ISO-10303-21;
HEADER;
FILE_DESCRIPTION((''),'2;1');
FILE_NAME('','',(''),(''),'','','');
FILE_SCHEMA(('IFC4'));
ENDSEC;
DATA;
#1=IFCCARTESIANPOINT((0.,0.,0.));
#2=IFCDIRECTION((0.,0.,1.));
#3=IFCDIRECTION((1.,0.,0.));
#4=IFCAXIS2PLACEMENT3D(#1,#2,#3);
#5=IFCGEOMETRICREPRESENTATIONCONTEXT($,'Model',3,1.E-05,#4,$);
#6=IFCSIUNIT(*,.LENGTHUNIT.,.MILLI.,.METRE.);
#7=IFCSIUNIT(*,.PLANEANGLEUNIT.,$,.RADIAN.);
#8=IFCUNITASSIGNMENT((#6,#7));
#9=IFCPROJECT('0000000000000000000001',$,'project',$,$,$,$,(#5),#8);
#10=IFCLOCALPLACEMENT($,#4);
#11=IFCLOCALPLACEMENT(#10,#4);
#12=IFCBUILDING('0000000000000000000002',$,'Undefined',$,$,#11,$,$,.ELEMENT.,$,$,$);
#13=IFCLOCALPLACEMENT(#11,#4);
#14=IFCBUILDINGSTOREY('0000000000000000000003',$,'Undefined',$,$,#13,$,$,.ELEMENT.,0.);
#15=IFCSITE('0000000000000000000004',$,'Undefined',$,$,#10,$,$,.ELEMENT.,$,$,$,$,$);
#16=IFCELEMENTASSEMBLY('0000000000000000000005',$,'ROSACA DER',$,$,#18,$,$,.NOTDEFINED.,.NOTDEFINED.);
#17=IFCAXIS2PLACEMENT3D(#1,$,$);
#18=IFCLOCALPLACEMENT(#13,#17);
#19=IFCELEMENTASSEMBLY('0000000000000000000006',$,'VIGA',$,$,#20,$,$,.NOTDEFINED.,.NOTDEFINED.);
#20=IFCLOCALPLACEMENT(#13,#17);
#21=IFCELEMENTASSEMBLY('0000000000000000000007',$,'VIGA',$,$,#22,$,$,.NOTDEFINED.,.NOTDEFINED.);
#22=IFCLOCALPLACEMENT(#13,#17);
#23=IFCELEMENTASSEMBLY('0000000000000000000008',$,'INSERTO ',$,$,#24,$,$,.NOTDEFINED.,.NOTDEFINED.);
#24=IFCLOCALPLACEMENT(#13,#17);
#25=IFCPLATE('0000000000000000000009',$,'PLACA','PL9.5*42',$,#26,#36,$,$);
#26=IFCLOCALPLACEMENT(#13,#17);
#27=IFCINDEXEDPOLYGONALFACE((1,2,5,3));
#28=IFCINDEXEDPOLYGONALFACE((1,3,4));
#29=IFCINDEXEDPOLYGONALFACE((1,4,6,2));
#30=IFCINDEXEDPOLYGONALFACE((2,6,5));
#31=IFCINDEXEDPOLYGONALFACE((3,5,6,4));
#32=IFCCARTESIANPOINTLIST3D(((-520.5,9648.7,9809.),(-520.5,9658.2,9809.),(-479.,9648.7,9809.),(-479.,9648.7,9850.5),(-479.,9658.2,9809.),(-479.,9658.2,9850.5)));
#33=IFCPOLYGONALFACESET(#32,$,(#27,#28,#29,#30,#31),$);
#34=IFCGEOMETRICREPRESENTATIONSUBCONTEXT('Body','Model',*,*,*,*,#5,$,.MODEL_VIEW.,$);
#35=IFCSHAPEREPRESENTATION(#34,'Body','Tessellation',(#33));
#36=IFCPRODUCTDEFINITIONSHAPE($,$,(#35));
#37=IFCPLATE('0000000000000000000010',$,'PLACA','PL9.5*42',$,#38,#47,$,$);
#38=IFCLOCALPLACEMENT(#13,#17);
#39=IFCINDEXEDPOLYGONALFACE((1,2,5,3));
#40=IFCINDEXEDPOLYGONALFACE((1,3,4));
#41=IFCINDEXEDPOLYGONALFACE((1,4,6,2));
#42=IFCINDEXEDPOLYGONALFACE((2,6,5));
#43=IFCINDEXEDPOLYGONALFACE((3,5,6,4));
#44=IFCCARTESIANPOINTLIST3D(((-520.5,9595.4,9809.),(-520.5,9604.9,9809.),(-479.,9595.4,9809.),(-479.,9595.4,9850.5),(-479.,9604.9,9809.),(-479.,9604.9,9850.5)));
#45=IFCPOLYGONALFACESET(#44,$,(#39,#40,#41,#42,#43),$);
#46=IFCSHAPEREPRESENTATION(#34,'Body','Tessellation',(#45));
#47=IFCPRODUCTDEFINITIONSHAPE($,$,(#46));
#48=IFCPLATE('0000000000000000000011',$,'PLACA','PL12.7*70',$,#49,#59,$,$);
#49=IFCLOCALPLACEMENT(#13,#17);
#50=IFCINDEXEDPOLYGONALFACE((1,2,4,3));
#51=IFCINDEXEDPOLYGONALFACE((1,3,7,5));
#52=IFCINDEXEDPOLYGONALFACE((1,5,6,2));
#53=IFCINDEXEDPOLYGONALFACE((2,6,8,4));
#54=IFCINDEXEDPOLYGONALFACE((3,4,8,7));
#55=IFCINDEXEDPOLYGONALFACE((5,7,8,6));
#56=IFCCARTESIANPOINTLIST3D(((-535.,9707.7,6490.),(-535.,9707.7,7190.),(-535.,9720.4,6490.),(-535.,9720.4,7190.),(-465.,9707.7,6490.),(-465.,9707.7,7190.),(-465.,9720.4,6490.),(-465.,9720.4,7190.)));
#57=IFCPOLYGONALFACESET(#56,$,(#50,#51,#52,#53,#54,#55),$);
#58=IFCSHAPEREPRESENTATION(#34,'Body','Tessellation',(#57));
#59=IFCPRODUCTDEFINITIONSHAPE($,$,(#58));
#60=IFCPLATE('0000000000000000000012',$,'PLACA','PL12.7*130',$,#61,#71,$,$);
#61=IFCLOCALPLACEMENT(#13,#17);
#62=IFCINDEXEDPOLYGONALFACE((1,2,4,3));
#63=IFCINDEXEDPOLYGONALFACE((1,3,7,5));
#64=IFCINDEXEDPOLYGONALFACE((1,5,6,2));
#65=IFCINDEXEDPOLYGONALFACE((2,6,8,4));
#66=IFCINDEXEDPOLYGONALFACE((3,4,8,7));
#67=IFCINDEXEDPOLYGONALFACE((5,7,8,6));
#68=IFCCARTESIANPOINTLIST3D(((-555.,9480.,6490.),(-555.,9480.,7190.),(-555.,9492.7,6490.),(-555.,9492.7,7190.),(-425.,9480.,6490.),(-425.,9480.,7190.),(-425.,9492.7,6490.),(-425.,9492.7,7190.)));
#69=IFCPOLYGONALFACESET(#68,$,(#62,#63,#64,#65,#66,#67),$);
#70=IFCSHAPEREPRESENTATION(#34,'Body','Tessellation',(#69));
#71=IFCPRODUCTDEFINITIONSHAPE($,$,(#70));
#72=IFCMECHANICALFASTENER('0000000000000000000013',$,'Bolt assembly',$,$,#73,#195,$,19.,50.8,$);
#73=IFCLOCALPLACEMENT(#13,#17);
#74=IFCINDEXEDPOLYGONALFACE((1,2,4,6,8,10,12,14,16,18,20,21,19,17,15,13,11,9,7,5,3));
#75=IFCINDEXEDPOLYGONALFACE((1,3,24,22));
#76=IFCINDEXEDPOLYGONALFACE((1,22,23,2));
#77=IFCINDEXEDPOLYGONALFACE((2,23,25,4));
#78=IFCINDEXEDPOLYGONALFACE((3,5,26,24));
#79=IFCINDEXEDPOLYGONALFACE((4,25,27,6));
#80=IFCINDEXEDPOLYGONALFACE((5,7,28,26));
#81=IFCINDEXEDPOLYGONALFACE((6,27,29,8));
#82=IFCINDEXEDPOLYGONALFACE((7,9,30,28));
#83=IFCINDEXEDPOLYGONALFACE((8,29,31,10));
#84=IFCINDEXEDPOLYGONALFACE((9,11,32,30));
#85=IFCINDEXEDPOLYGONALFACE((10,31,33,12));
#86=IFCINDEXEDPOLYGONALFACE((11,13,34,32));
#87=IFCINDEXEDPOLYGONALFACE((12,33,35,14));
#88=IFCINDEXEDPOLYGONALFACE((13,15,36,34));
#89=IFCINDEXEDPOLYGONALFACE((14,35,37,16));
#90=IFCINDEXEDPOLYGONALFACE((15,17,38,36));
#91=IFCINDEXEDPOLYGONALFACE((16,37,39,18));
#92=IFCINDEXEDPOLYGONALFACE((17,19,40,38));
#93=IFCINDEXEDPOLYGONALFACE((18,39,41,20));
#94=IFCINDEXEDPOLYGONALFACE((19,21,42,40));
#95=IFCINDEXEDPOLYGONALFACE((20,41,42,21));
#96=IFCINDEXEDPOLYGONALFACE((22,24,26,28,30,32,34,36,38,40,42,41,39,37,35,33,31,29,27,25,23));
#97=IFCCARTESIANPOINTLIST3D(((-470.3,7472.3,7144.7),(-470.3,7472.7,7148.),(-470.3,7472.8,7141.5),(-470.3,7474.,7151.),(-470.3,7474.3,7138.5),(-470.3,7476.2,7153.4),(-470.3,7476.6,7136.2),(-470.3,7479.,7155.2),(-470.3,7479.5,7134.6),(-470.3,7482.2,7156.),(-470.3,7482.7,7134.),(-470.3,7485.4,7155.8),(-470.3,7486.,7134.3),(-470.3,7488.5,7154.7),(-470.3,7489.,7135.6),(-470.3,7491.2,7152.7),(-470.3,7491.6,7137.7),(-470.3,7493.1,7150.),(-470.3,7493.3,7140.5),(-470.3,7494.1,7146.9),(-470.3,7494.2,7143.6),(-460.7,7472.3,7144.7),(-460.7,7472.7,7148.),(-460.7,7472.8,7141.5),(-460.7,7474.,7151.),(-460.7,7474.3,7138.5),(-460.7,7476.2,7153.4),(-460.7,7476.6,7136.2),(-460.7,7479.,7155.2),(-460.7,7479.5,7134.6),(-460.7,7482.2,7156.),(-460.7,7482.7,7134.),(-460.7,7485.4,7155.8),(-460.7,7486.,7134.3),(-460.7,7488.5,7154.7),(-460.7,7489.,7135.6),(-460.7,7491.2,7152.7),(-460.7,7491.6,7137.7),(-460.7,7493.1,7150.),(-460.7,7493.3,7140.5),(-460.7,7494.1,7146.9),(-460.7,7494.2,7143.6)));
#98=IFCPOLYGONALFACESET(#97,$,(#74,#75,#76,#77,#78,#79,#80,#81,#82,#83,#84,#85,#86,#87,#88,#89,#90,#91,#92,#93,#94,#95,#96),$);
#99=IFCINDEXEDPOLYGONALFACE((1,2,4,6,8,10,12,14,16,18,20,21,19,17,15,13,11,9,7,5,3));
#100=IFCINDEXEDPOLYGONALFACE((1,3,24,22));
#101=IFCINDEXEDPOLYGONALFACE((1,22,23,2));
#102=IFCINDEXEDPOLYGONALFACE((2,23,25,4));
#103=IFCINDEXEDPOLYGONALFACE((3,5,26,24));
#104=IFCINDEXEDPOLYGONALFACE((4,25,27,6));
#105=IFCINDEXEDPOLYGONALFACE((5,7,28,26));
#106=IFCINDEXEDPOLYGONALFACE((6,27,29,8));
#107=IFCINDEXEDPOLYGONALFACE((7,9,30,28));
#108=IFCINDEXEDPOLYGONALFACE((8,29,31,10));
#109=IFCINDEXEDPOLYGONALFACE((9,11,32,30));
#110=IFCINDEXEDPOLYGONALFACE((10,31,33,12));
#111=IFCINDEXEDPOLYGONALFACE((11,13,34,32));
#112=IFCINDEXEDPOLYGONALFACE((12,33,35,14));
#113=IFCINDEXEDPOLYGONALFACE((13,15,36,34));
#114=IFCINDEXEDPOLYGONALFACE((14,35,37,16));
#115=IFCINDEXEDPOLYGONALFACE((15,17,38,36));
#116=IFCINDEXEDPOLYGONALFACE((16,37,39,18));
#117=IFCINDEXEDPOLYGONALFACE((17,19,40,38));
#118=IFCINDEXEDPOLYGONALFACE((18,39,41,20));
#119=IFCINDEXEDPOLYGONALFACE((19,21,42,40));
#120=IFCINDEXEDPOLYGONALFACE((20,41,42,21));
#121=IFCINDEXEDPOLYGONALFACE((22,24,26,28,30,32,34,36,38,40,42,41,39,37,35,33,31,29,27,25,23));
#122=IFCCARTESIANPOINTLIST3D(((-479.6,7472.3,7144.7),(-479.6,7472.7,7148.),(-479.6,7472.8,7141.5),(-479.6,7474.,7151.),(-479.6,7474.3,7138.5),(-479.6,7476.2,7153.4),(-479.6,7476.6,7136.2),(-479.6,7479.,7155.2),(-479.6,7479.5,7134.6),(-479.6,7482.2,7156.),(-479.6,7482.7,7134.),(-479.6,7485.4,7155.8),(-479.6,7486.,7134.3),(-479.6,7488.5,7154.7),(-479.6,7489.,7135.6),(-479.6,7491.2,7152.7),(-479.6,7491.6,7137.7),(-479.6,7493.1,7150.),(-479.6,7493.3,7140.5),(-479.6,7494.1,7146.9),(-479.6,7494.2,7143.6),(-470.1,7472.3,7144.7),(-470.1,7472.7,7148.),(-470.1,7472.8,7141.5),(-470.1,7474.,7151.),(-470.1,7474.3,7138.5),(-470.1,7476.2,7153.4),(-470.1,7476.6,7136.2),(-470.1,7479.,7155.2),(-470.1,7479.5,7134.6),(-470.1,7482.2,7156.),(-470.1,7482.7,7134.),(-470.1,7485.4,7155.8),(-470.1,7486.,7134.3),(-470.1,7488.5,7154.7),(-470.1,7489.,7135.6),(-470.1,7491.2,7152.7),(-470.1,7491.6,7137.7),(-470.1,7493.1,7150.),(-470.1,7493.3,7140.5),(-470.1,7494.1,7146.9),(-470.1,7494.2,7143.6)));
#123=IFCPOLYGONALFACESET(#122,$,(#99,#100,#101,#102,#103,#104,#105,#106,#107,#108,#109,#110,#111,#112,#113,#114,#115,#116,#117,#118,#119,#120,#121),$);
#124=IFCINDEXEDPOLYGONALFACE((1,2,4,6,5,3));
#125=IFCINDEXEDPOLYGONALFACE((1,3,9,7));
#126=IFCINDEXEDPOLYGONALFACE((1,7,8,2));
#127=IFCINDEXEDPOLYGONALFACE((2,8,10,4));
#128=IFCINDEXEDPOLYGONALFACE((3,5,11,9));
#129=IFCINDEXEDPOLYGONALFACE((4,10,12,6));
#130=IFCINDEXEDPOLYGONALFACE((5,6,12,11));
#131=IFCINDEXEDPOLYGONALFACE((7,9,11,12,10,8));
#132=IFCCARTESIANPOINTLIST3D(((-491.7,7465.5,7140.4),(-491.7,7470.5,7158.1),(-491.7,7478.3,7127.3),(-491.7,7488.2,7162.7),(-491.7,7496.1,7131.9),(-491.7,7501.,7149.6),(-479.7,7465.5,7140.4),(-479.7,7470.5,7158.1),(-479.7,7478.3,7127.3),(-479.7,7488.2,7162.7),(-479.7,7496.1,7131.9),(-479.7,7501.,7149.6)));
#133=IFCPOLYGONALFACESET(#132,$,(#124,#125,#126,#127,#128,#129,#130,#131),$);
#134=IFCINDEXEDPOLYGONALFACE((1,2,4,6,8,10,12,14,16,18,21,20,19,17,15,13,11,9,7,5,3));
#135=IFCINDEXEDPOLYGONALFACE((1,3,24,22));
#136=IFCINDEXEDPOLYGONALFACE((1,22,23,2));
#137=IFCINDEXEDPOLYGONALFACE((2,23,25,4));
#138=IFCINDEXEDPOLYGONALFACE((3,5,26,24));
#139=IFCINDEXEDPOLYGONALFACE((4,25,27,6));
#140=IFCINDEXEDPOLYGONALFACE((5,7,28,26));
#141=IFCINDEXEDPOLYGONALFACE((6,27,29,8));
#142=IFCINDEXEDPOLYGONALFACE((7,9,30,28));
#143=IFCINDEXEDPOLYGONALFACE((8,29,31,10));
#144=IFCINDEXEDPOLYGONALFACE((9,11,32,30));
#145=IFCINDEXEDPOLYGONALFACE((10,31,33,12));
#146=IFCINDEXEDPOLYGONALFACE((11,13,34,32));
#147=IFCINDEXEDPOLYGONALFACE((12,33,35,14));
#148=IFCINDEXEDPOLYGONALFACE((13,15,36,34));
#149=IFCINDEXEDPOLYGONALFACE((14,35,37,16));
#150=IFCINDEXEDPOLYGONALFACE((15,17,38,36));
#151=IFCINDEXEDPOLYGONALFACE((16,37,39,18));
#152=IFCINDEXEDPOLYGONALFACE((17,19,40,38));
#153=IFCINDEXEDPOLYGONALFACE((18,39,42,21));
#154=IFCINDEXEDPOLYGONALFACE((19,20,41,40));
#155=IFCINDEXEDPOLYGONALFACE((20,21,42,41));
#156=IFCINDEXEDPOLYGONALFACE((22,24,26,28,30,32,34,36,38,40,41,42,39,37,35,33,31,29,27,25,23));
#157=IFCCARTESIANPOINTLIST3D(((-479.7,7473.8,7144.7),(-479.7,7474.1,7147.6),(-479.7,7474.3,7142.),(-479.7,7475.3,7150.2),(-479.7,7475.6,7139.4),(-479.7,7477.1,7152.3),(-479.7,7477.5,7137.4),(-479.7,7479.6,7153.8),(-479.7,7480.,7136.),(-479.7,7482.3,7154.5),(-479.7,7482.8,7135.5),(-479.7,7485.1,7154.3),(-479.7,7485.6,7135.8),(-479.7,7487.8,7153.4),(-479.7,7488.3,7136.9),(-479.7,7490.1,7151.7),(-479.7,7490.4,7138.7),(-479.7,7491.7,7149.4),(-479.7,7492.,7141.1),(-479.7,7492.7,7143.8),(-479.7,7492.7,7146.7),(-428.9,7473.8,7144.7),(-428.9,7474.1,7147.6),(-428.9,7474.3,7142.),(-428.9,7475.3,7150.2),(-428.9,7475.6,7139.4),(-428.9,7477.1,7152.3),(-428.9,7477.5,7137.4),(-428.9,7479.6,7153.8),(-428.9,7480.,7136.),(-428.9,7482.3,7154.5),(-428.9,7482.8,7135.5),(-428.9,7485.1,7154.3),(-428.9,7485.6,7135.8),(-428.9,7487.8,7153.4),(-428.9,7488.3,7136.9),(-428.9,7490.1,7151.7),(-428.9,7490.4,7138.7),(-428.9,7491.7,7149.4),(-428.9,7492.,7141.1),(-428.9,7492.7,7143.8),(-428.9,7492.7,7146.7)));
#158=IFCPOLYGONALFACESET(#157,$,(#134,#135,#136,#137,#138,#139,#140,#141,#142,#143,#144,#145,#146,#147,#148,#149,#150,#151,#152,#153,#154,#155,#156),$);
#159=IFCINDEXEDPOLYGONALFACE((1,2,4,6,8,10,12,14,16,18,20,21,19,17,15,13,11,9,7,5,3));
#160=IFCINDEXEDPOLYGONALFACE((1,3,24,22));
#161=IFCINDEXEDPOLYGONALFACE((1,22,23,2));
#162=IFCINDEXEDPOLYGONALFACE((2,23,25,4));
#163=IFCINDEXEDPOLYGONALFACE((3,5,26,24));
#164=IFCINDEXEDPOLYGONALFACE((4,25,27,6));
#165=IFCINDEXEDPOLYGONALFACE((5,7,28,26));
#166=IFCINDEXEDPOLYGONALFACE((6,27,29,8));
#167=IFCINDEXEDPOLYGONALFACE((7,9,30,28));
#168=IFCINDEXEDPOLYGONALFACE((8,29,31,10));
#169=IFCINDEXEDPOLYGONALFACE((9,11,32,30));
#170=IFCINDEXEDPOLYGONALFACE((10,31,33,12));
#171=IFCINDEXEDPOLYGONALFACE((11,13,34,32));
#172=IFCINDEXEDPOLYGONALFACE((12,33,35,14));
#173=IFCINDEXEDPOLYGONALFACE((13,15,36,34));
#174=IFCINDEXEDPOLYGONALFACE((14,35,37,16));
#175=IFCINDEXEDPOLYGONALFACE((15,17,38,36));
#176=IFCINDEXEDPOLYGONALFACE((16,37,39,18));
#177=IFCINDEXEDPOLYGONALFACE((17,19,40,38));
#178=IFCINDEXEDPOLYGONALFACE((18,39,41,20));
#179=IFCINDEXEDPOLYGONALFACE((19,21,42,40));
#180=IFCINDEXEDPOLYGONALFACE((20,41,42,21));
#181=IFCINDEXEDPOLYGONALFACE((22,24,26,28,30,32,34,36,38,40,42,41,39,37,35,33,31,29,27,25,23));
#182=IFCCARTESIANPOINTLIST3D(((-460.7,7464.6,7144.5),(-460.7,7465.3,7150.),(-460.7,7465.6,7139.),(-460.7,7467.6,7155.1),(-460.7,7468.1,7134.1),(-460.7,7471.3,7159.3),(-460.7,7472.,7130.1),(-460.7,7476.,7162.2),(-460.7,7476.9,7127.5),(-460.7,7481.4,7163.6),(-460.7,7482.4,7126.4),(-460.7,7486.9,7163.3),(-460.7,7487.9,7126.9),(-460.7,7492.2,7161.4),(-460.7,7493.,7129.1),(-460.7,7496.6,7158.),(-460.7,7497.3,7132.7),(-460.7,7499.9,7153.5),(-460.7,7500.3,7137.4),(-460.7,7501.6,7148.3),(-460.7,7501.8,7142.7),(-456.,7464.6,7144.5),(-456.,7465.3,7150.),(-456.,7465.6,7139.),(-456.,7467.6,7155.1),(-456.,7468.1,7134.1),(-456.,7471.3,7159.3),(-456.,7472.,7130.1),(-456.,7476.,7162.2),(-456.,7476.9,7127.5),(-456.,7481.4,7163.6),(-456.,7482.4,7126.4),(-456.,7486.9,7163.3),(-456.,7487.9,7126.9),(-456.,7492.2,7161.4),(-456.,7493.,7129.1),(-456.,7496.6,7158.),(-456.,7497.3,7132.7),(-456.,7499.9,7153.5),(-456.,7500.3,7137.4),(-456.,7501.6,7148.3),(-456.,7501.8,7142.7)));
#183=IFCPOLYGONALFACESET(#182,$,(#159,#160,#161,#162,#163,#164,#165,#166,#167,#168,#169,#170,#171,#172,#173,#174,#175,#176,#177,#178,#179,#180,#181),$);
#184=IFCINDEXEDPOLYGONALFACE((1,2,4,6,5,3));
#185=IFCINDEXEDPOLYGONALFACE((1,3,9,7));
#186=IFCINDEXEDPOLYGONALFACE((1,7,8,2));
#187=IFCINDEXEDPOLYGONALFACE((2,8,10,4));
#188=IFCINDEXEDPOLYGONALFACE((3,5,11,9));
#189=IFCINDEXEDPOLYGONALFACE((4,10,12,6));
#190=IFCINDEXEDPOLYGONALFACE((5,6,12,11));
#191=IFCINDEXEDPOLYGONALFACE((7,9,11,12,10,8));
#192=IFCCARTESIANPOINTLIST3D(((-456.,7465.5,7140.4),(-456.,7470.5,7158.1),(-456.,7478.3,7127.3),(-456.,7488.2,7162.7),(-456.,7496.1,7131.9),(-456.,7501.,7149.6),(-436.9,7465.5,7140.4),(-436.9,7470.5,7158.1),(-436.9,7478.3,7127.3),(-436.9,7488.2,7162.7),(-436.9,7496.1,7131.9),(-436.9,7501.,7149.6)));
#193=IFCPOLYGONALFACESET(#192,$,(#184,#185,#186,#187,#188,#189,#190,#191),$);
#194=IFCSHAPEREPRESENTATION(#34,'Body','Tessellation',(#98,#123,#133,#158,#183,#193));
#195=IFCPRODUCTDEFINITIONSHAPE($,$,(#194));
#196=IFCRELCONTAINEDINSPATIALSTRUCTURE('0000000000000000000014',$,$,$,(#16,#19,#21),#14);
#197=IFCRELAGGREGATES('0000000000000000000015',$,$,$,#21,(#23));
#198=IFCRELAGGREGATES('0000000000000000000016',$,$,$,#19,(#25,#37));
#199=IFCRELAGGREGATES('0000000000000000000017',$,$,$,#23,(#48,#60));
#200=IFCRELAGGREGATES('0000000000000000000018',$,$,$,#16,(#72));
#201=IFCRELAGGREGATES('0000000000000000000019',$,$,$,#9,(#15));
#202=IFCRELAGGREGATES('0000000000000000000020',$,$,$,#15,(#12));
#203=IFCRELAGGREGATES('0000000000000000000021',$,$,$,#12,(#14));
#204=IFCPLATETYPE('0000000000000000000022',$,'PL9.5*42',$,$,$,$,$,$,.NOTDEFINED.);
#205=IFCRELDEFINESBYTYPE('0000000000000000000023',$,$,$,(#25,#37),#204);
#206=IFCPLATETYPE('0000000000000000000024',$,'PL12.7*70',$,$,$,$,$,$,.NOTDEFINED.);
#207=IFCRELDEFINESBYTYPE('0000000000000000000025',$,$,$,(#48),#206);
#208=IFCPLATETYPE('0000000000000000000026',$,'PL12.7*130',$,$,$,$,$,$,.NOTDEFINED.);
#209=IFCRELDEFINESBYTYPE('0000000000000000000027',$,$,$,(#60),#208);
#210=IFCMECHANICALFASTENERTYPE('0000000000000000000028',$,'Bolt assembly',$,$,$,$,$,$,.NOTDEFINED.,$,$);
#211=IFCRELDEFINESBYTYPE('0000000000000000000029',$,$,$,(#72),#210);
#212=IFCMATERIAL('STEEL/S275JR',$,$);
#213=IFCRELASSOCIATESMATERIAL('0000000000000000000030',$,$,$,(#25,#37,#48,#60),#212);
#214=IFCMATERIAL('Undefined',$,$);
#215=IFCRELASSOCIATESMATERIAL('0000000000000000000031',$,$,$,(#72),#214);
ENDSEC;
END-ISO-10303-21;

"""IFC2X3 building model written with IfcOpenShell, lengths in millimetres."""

from ifc_helpers import new_model, si_unit, frame, origin_with_axes, origin_2d_with_axis, place, context, subcontext, project, spatial, polyline, circle, outline, extrude, source, transform, mapped, material, type_object, element, aggregate, save


model = new_model("IFC2X3")

# Units and contexts
model_context = context("Model", 3, precision=1e-05, world=origin_with_axes())
body_context = subcontext(model_context, "Body", "Model", "MODEL_VIEW")
ifc_project = project(units=[si_unit("LENGTHUNIT", "METRE", prefix="MILLI"), si_unit("PLANEANGLEUNIT", "RADIAN")], contexts=[model_context])

# Site, building, storey
site_placement = place(None, origin_with_axes())
site = spatial("IfcSite", under=ifc_project, at=site_placement, Name="Undefined", CompositionType="ELEMENT")
building_placement = place(site_placement, origin_with_axes())
building = spatial("IfcBuilding", under=site, at=building_placement, Name="Undefined", CompositionType="ELEMENT")
storey_placement = place(building_placement, origin_with_axes())
storey = spatial("IfcBuildingStorey", under=building, at=storey_placement, Name="Undefined", CompositionType="ELEMENT", Elevation=0.0)

# Shared definitions
ifc_material_1 = material(Name="STEEL/S275JR")

# Element assemblies
assembly_1_placement = place(storey_placement, origin_with_axes())
assembly_1 = element("IfcElementAssembly", 1, at=assembly_1_placement, inside=storey, Name="ROSACA DER", AssemblyPlace="NOTDEFINED", PredefinedType="NOTDEFINED")
assembly_2_placement = place(storey_placement, origin_with_axes())
assembly_2 = element("IfcElementAssembly", 2, at=assembly_2_placement, inside=storey, Name="VIGA", AssemblyPlace="NOTDEFINED", PredefinedType="NOTDEFINED")

# Element assemblies
assembly_3_placement = place(storey_placement, origin_with_axes())
assembly_3 = element("IfcElementAssembly", 3, at=assembly_3_placement, inside=storey, Name="VIGA", AssemblyPlace="NOTDEFINED", PredefinedType="NOTDEFINED")
assembly_4_placement = place(assembly_3_placement, origin_with_axes())
assembly_4 = element("IfcElementAssembly", 4, at=assembly_4_placement, Name="INSERTO ", AssemblyPlace="NOTDEFINED", PredefinedType="NOTDEFINED")
aggregate(assembly_3, [assembly_4])
plate_type_1 = type_object("IfcPlateType", Name="PL9.5*42", PredefinedType="NOTDEFINED")

# Plates
plate_1_placement = place(assembly_2_placement, frame((-479.0, 9653.4, 9809.0), z_axis=(0.0, -1.0, 0.0), x_axis=(0.0, 0.0, 1.0)))
plate_1 = element("IfcPlate", 5, at=plate_1_placement, type_object=plate_type_1, material=ifc_material_1, Name="PLACA", Description="PL9.5*42", context=body_context, shape_type="SweptSolid", body=[
    extrude(outline(polyline([(0.0, 0.0), (41.5, 0.0), (0.0, 41.5), (0.0, 0.0)])), frame((0.0, 0.0, -4.7), z_axis=(0.0, 0.0, 1.0), x_axis=(1.0, 0.0, 0.0)), (0.0, 0.0, 1.0), 9.5),
])
plate_2_placement = place(assembly_2_placement, frame((-479.0, 9600.2, 9809.0), z_axis=(0.0, -1.0, 0.0), x_axis=(0.0, 0.0, 1.0)))
plate_2 = element("IfcPlate", 6, at=plate_2_placement, type_object=plate_type_1, material=ifc_material_1, Name="PLACA", Description="PL9.5*42", context=body_context, shape_type="SweptSolid", body=[
    extrude(outline(polyline([(0.0, 0.0), (41.5, 0.0), (0.0, 41.5), (0.0, 0.0)])), frame((0.0, 0.0, -4.7), z_axis=(0.0, 0.0, 1.0), x_axis=(1.0, 0.0, 0.0)), (0.0, 0.0, 1.0), 9.5),
])
aggregate(assembly_2, [plate_1, plate_2])
plate_type_2 = type_object("IfcPlateType", Name="PL12.7*70", PredefinedType="NOTDEFINED")
plate_3_placement = place(assembly_4_placement, frame((-465.0, 9714.0, 7190.0), z_axis=(0.0, -1.0, 0.0), x_axis=(-1.0, 0.0, 0.0)))
plate_3 = element("IfcPlate", 7, at=plate_3_placement, type_object=plate_type_2, material=ifc_material_1, Name="PLACA", Description="PL12.7*70", context=body_context, shape_type="SweptSolid", body=[
    extrude(outline(polyline([(0.0, 0.0), (70.0, 0.0), (70.0, 700.0), (0.0, 700.0), (0.0, 0.0)])), frame((0.0, 0.0, -6.3), z_axis=(0.0, 0.0, 1.0), x_axis=(1.0, 0.0, 0.0)), (0.0, 0.0, 1.0), 12.7),
])
plate_type_3 = type_object("IfcPlateType", Name="PL12.7*130", PredefinedType="NOTDEFINED")
plate_4_placement = place(assembly_4_placement, frame((-425.0, 9486.3, 7190.0), z_axis=(0.0, -1.0, 0.0), x_axis=(-1.0, 0.0, 0.0)))
plate_4 = element("IfcPlate", 8, at=plate_4_placement, type_object=plate_type_3, material=ifc_material_1, Name="PLACA", Description="PL12.7*130", context=body_context, shape_type="SweptSolid", body=[
    extrude(outline(polyline([(0.0, 0.0), (130.0, 0.0), (130.0, 700.0), (0.0, 700.0), (0.0, 0.0)])), frame((0.0, 0.0, -6.3), z_axis=(0.0, 0.0, 1.0), x_axis=(1.0, 0.0, 0.0)), (0.0, 0.0, 1.0), 12.7),
])
aggregate(assembly_4, [plate_3, plate_4])

# Mechanical fastener
ifc_material_2 = material(Name="Undefined")
mechanical_fastener_type = type_object("IfcMechanicalFastenerType", Name="Bolt assembly")
shared_shape_1 = source(origin_with_axes(), body_context, "Body", "SweptSolid", [
    extrude(circle(Radius=11.0, at=origin_2d_with_axis()), frame((0.0, 4.6, 0.0), z_axis=(0.0, 1.0, 0.0), x_axis=(1.0, 0.0, 0.0)), (0.0, 0.0, 1.0), 9.6),
    extrude(circle(Radius=11.0, at=origin_2d_with_axis()), frame((0.0, -4.6, 0.0), z_axis=(0.0, 1.0, 0.0), x_axis=(1.0, 0.0, 0.0)), (0.0, 0.0, 1.0), 9.5),
    extrude(outline(polyline([(15.9, -9.2), (15.9, 9.2), (0.0, 18.3), (-15.9, 9.2), (-15.9, -9.2), (0.0, -18.3), (15.9, -9.2)])), frame((0.0, -16.7, 0.0), z_axis=(0.0, 1.0, 0.0), x_axis=(1.0, 0.0, 0.0)), (0.0, 0.0, 1.0), 11.9),
    extrude(circle(Radius=9.5, at=origin_2d_with_axis()), frame((0.0, -4.7, 0.0), z_axis=(0.0, 1.0, 0.0), x_axis=(1.0, 0.0, 0.0)), (0.0, 0.0, 1.0), 50.8),
    extrude(circle(Radius=18.7, at=origin_2d_with_axis()), frame((0.0, 14.2, 0.0), z_axis=(0.0, 1.0, 0.0), x_axis=(1.0, 0.0, 0.0)), (0.0, 0.0, 1.0), 4.8),
    extrude(outline(polyline([(15.9, -9.2), (15.9, 9.2), (0.0, 18.3), (-15.9, 9.2), (-15.9, -9.2), (0.0, -18.3), (15.9, -9.2)])), frame((0.0, 19.0, 0.0), z_axis=(0.0, 1.0, 0.0), x_axis=(1.0, 0.0, 0.0)), (0.0, 0.0, 1.0), 19.1),
])
mechanical_fastener_1_placement = place(assembly_1_placement, frame((-475.0, 7483.3, 7145.0), z_axis=(0.0, 0.269246, 0.963072), x_axis=(0.0, -0.963072, 0.269246)))
mechanical_fastener_1 = element("IfcMechanicalFastener", 9, at=mechanical_fastener_1_placement, type_object=mechanical_fastener_type, material=ifc_material_2, Name="Bolt assembly", NominalDiameter=19.0, NominalLength=50.8, context=body_context, shape_type="MappedRepresentation", body=[
    mapped(shared_shape_1, transform((0.0, 0.0, 0.0))),
])
aggregate(assembly_1, [mechanical_fastener_1])

save(model, "model.ifc")
